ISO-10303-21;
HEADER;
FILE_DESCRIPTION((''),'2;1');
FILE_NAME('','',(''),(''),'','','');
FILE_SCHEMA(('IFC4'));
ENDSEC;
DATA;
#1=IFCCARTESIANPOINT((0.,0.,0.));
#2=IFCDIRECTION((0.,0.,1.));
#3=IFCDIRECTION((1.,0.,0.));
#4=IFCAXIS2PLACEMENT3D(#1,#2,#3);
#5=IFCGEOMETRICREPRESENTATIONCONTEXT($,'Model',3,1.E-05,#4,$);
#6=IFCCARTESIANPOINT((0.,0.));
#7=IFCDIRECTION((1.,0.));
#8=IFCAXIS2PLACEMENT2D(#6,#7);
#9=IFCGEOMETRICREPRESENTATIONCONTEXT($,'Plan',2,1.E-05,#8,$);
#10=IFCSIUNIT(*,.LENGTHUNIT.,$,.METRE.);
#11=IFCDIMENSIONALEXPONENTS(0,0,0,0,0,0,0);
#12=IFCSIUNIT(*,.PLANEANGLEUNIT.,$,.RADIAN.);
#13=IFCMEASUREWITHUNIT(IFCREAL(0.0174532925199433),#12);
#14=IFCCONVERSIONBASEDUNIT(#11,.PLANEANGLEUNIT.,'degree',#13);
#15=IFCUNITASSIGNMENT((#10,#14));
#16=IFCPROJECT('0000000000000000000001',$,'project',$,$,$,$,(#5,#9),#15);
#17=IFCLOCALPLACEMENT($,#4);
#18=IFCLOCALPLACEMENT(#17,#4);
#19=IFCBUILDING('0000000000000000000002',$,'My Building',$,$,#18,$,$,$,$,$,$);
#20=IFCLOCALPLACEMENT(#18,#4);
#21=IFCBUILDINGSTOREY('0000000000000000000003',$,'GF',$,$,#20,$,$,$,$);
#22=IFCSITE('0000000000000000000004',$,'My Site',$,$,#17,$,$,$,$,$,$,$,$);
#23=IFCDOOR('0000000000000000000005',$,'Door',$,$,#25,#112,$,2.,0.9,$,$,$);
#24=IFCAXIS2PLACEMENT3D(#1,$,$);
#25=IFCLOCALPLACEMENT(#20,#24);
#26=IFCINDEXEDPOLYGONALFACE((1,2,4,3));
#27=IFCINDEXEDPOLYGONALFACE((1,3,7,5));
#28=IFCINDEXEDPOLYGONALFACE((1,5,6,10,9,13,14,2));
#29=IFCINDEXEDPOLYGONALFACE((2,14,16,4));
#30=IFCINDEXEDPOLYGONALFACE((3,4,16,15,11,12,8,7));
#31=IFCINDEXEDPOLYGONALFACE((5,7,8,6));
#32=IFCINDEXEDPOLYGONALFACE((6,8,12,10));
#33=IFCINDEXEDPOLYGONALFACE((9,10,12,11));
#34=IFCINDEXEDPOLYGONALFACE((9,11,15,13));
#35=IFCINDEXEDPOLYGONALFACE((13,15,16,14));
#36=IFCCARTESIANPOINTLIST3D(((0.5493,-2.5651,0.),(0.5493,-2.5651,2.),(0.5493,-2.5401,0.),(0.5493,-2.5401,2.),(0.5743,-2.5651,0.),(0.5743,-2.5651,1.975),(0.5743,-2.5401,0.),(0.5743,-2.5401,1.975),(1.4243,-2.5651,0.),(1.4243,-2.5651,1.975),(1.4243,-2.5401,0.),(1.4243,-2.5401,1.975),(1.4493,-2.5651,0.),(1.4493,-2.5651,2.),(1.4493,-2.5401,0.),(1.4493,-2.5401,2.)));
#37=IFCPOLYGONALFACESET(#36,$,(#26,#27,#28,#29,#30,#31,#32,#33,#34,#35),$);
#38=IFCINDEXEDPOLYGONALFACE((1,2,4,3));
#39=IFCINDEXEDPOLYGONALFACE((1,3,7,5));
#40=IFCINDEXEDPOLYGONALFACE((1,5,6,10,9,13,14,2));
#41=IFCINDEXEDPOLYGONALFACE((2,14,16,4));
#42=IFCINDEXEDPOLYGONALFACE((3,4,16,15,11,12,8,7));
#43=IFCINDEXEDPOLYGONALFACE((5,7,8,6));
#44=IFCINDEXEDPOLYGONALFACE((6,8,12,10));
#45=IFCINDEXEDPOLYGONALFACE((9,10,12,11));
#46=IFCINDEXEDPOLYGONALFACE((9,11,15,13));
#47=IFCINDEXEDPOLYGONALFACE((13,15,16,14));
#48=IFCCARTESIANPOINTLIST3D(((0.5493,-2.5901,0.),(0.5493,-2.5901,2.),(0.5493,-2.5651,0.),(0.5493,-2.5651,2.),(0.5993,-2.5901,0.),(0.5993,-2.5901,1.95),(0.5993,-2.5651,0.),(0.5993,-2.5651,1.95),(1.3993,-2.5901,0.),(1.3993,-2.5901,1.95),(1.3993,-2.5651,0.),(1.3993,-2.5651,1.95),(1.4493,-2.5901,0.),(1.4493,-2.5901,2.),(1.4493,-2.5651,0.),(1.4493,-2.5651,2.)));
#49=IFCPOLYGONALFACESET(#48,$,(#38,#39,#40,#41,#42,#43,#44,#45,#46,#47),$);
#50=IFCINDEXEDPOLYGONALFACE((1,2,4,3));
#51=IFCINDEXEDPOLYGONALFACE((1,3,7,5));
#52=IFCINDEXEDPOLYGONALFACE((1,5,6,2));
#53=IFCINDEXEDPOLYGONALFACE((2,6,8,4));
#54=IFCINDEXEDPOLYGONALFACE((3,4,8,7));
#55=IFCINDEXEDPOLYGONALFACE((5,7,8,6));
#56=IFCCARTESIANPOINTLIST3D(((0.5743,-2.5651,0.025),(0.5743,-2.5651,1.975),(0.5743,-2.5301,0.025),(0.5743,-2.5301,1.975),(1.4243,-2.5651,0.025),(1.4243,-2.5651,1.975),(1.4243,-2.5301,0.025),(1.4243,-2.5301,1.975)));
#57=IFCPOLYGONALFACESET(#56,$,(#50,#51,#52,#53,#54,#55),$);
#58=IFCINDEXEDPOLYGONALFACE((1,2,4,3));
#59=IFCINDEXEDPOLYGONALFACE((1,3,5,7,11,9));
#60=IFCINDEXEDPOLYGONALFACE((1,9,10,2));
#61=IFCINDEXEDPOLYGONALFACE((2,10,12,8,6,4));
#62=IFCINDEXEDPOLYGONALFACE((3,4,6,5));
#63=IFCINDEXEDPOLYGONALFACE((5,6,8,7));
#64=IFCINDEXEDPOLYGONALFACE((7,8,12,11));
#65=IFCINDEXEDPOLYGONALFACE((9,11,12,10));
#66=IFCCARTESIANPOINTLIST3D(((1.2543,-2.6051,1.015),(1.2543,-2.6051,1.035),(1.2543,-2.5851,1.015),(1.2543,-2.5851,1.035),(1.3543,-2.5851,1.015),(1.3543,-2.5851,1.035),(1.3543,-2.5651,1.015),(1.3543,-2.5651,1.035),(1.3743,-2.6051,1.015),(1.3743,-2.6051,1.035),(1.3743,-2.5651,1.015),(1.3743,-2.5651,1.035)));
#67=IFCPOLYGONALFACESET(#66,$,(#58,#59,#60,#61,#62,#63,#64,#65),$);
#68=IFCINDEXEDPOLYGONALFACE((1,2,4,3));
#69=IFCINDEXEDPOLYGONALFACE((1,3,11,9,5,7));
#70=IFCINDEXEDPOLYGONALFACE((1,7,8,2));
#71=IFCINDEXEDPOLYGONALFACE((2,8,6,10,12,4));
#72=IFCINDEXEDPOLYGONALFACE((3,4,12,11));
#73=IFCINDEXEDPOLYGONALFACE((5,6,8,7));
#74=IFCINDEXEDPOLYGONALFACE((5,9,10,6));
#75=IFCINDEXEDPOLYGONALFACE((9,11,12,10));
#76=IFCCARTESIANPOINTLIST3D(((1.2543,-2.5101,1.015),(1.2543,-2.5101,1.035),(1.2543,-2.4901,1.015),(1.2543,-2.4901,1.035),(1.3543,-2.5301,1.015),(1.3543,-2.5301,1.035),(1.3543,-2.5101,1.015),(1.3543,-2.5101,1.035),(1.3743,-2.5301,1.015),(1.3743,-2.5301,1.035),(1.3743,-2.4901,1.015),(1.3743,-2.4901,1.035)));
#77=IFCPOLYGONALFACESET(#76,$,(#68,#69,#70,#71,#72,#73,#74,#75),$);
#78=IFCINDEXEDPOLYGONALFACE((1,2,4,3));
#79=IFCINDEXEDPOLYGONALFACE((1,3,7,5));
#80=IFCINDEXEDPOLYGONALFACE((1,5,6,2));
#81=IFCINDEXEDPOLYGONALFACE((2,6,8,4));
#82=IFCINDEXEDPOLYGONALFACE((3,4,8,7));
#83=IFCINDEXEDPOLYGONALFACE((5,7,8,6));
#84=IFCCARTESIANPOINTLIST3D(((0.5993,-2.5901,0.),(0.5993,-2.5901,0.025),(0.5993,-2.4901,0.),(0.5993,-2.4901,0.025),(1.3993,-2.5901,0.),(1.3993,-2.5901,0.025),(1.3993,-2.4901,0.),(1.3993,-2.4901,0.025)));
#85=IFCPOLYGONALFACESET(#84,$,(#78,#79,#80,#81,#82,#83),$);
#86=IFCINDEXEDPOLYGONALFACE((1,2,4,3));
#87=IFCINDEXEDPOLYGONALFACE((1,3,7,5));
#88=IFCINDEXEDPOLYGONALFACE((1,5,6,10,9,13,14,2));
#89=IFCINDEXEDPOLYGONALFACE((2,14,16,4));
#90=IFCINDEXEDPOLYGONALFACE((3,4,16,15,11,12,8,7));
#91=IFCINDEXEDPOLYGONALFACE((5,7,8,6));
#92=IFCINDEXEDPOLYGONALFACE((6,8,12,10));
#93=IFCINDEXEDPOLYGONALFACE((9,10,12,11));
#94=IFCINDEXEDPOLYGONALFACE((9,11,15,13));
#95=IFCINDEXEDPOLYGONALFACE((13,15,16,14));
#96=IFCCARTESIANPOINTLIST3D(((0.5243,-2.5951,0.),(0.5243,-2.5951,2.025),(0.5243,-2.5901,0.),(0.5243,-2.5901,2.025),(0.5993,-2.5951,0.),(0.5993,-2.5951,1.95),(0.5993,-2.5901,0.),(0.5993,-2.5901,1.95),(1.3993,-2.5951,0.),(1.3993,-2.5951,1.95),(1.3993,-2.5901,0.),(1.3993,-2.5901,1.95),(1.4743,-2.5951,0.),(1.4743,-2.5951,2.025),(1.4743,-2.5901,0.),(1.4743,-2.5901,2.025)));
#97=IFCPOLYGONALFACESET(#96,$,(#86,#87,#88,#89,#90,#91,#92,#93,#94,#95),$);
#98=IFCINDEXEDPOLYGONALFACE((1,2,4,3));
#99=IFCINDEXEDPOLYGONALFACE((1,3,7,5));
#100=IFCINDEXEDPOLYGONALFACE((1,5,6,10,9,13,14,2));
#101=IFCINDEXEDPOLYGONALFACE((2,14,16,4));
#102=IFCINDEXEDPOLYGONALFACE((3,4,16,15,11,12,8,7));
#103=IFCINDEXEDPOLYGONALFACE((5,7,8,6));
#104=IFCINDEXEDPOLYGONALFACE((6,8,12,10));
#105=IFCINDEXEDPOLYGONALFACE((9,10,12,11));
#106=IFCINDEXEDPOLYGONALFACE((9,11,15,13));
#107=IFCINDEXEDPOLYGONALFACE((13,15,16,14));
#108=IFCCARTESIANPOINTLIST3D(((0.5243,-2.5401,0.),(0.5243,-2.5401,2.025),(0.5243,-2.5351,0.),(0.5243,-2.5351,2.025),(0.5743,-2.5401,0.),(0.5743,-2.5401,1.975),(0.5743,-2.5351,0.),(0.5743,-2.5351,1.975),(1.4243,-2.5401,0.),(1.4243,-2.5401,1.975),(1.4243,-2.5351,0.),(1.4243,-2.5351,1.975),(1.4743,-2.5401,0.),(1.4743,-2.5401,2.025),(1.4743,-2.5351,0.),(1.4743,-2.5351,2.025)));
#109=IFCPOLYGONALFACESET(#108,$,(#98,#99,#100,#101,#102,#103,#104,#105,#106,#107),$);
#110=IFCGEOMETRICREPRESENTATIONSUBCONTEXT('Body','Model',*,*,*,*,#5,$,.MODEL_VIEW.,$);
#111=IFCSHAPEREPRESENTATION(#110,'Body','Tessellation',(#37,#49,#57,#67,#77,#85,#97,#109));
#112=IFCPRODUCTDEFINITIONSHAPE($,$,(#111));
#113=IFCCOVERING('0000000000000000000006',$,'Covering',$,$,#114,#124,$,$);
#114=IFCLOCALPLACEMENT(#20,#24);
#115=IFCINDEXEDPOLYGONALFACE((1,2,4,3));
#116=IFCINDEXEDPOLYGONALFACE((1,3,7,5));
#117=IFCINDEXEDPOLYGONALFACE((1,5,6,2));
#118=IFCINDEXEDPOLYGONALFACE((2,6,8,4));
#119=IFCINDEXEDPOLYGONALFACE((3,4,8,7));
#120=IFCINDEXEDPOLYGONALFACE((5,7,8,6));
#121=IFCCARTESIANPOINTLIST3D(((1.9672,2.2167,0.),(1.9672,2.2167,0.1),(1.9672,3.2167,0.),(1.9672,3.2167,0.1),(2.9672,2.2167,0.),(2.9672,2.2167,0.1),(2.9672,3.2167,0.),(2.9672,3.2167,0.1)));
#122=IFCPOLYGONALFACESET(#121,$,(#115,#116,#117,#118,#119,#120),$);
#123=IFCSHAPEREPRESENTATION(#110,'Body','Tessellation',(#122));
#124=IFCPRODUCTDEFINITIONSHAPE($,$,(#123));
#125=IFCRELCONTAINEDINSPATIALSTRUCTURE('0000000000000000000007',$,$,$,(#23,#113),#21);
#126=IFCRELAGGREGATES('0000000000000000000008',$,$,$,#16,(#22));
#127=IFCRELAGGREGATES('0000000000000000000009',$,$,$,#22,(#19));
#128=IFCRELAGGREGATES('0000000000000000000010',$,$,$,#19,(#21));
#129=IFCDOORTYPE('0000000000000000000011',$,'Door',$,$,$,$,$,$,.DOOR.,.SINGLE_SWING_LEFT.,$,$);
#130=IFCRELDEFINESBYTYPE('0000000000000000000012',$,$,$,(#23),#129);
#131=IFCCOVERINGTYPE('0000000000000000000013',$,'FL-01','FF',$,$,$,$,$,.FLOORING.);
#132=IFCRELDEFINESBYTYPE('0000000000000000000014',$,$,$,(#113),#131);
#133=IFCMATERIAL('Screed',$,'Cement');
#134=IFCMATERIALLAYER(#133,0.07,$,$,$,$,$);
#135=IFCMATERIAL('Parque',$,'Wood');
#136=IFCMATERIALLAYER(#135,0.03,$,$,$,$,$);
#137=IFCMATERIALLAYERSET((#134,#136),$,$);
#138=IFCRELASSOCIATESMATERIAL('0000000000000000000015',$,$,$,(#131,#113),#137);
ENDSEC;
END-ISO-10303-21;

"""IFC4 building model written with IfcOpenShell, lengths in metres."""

from ifc_helpers import new_model, entity, si_unit, converted_unit, frame, origin_with_axes, origin_2d_with_axis, place, context, subcontext, project, spatial, line, indexed_curve, outline, extrude, shape, source, transform, mapped, material, layer, layer_set, layer_usage, type_object, type_shapes, element, save


model = new_model("IFC4")

# Units and contexts
model_context = context("Model", 3, precision=1e-05, world=origin_with_axes())
plan_context = context("Plan", 2, precision=1e-05, world=origin_2d_with_axis())
body_context_1 = subcontext(model_context, "Body", "Model", "MODEL_VIEW")
body_context_2 = subcontext(plan_context, "Body", "Plan", "PLAN_VIEW")
ifc_project = project(units=[si_unit("LENGTHUNIT", "METRE"), converted_unit("PLANEANGLEUNIT", "degree", entity("IfcReal", 0.0174532925199433), si_unit("PLANEANGLEUNIT", "RADIAN"), dimensions=[0, 0, 0, 0, 0, 0, 0])], contexts=[model_context, plan_context])

# Site, building, storey
site_placement = place(None, origin_with_axes())
site = spatial("IfcSite", under=ifc_project, at=site_placement, Name="My Site")
building_placement = place(site_placement, origin_with_axes())
building = spatial("IfcBuilding", under=site, at=building_placement, Name="My Building")
storey_placement = place(building_placement, origin_with_axes())
storey = spatial("IfcBuildingStorey", under=building, at=storey_placement, Name="GF")

# Shared definitions
door_type = type_object("IfcDoorType", Name="Door", OperationType="SINGLE_SWING_LEFT", PredefinedType="DOOR")
shared_shape_1 = source(origin_with_axes(), body_context_1, "Body", "SweptSolid", [
    extrude(outline(indexed_curve([(0.0, 0.0), (0.0, 2.0), (0.9, 2.0), (0.9, 0.0), (0.875, 0.0), (0.875, 1.975), (0.025, 1.975), (0.025, 0.0)], segments=[line(1, 2, 3, 4, 5, 6, 7, 8, 1)])), frame((0.0, 0.025, 0.0), z_axis=(0.0, -1.0, 0.0), x_axis=(1.0, 0.0, 0.0)), (0.0, 0.0, -1.0), 0.025),
    extrude(outline(indexed_curve([(0.0, 0.0), (0.0, 2.0), (0.9, 2.0), (0.9, 0.0), (0.85, 0.0), (0.85, 1.95), (0.05, 1.95), (0.05, 0.0)], segments=[line(1, 2, 3, 4, 5, 6, 7, 8, 1)])), frame((0.0, 0.0, 0.0), z_axis=(0.0, -1.0, 0.0), x_axis=(1.0, 0.0, 0.0)), (0.0, 0.0, -1.0), 0.025),
    extrude(outline(indexed_curve([(0.0, 0.0), (0.85, 0.0), (0.85, 0.035), (0.0, 0.035)], segments=[line(1, 2, 3, 4, 1)])), frame((0.025, 0.025, 0.025), z_axis=(0.0, 0.0, 1.0), x_axis=(1.0, 0.0, 0.0)), (0.0, 0.0, 1.0), 1.95),
    extrude(outline(indexed_curve([(0.0, 0.0), (0.0, -0.04), (-0.12, -0.04), (-0.12, -0.02), (-0.02, -0.02), (-0.02, 0.0)], segments=[line(1, 2, 3, 4, 5, 6, 1)])), frame((0.825, 0.025, 1.015), z_axis=(0.0, 0.0, 1.0), x_axis=(1.0, 0.0, 0.0)), (0.0, 0.0, 1.0), 0.02),
    extrude(outline(indexed_curve([(0.0, 0.0), (0.0, 0.04), (-0.12, 0.04), (-0.12, 0.02), (-0.02, 0.02), (-0.02, 0.0)], segments=[line(1, 2, 3, 4, 5, 6, 1)])), frame((0.825, 0.06, 1.015), z_axis=(0.0, 0.0, 1.0), x_axis=(1.0, 0.0, 0.0)), (0.0, 0.0, 1.0), 0.02),
    extrude(outline(indexed_curve([(0.0, 0.0), (0.8, 0.0), (0.8, 0.1), (0.0, 0.1)], segments=[line(1, 2, 3, 4, 1)])), frame((0.05, 0.0, 0.0), z_axis=(0.0, 0.0, 1.0), x_axis=(1.0, 0.0, 0.0)), (0.0, 0.0, 1.0), 0.025),
    extrude(outline(indexed_curve([(0.0, 0.0), (0.0, 2.025), (0.95, 2.025), (0.95, 0.0), (0.875, 0.0), (0.875, 1.95), (0.075, 1.95), (0.075, 0.0)], segments=[line(1, 2, 3, 4, 5, 6, 7, 8, 1)])), frame((-0.025, -0.005, 0.0), z_axis=(0.0, -1.0, 0.0), x_axis=(1.0, 0.0, 0.0)), (0.0, 0.0, -1.0), 0.005),
    extrude(outline(indexed_curve([(0.0, 0.0), (0.0, 2.025), (0.95, 2.025), (0.95, 0.0), (0.9, 0.0), (0.9, 1.975), (0.05, 1.975), (0.05, 0.0)], segments=[line(1, 2, 3, 4, 5, 6, 7, 8, 1)])), frame((-0.025, 0.05, 0.0), z_axis=(0.0, -1.0, 0.0), x_axis=(1.0, 0.0, 0.0)), (0.0, 0.0, -1.0), 0.005),
])
shared_shape_2 = source(origin_with_axes(), body_context_2, "Body", "Curve2D", [
    entity("IfcIndexedPolyCurve", entity("IfcCartesianPointList2D", [[0.0, 0.0], [0.0, 0.05], [0.025, 0.05], [0.025, 0.025], [0.05, 0.025], [0.05, 0.0]]), [entity("IfcLineIndex", [1, 2, 3, 4, 5, 6, 1])]),
    entity("IfcIndexedPolyCurve", entity("IfcCartesianPointList2D", [[0.9, 0.0], [0.9, 0.05], [0.875, 0.05], [0.875, 0.025], [0.85, 0.025], [0.85, 0.0]]), [entity("IfcLineIndex", [1, 2, 3, 4, 5, 6, 1])]),
    entity("IfcTrimmedCurve", entity("IfcEllipse", entity("IfcAxis2Placement2D", entity("IfcCartesianPoint", [0.06, 0.05]), entity("IfcDirection", [1.0, 0.0])), 0.815, 0.85), [entity("IfcCartesianPoint", [0.875, 0.05])], [entity("IfcCartesianPoint", [0.06, 0.9])], True, "CARTESIAN"),
    entity("IfcIndexedPolyCurve", entity("IfcCartesianPointList2D", [[0.025, 0.05], [0.06, 0.05], [0.06, 0.9], [0.025, 0.9]]), [entity("IfcLineIndex", [1, 2, 3, 4, 1])]),
])
type_shapes(door_type, [shared_shape_1, shared_shape_2])

# Door
door_1_placement = place(storey_placement, frame((0.5493, -2.5901, 0.0), z_axis=(0.0, 0.0, 1.0), x_axis=(1.0, 0.0, 0.0)))
element("IfcDoor", 1, at=door_1_placement, inside=storey, type_object=door_type, Name="Door", OverallHeight=2.0, OverallWidth=0.9, shapes=[
    shape(body_context_1, "Body", "MappedRepresentation", [mapped(shared_shape_1, transform((0.0, 0.0, 0.0), x_axis=(1.0, 0.0, 0.0), y_axis=(0.0, 1.0, 0.0), z_axis=(0.0, 0.0, 1.0), scale=1.0))]),
    shape(body_context_2, "Body", "MappedRepresentation", [mapped(shared_shape_2, transform((0.0, 0.0, 0.0), x_axis=(1.0, 0.0, 0.0), y_axis=(0.0, 1.0, 0.0), z_axis=(0.0, 0.0, 1.0), scale=1.0))]),
])

# Covering
ifc_material_1 = material(Name="Screed", Category="Cement")
ifc_layer_1 = layer(ifc_material_1, 0.07)
ifc_material_2 = material(Name="Parque", Category="Wood")
ifc_layer_2 = layer(ifc_material_2, 0.03)
ifc_layer_set_1 = layer_set([ifc_layer_1, ifc_layer_2])
ifc_layer_usage_1 = layer_usage(ifc_layer_set_1, "AXIS3", "POSITIVE", 0.0)
covering_type = type_object("IfcCoveringType", Name="FL-01", Description="FF", PredefinedType="FLOORING", material=ifc_layer_set_1)
covering_placement = place(storey_placement, frame((1.9672, 2.2167, 0.0), z_axis=(0.0, 0.0, 1.0), x_axis=(1.0, 0.0, 0.0)))
element("IfcCovering", 2, at=covering_placement, inside=storey, type_object=covering_type, material=ifc_layer_usage_1, Name="Covering", context=body_context_1, shape_type="SweptSolid", body=[
    extrude(outline(indexed_curve([(0.0, 0.0), (1.0, 0.0), (1.0, 1.0), (0.0, 1.0), (0.0, 0.0)])), None, (0.0, 0.0, 1.0), 0.1),
])

save(model, "model.ifc")
